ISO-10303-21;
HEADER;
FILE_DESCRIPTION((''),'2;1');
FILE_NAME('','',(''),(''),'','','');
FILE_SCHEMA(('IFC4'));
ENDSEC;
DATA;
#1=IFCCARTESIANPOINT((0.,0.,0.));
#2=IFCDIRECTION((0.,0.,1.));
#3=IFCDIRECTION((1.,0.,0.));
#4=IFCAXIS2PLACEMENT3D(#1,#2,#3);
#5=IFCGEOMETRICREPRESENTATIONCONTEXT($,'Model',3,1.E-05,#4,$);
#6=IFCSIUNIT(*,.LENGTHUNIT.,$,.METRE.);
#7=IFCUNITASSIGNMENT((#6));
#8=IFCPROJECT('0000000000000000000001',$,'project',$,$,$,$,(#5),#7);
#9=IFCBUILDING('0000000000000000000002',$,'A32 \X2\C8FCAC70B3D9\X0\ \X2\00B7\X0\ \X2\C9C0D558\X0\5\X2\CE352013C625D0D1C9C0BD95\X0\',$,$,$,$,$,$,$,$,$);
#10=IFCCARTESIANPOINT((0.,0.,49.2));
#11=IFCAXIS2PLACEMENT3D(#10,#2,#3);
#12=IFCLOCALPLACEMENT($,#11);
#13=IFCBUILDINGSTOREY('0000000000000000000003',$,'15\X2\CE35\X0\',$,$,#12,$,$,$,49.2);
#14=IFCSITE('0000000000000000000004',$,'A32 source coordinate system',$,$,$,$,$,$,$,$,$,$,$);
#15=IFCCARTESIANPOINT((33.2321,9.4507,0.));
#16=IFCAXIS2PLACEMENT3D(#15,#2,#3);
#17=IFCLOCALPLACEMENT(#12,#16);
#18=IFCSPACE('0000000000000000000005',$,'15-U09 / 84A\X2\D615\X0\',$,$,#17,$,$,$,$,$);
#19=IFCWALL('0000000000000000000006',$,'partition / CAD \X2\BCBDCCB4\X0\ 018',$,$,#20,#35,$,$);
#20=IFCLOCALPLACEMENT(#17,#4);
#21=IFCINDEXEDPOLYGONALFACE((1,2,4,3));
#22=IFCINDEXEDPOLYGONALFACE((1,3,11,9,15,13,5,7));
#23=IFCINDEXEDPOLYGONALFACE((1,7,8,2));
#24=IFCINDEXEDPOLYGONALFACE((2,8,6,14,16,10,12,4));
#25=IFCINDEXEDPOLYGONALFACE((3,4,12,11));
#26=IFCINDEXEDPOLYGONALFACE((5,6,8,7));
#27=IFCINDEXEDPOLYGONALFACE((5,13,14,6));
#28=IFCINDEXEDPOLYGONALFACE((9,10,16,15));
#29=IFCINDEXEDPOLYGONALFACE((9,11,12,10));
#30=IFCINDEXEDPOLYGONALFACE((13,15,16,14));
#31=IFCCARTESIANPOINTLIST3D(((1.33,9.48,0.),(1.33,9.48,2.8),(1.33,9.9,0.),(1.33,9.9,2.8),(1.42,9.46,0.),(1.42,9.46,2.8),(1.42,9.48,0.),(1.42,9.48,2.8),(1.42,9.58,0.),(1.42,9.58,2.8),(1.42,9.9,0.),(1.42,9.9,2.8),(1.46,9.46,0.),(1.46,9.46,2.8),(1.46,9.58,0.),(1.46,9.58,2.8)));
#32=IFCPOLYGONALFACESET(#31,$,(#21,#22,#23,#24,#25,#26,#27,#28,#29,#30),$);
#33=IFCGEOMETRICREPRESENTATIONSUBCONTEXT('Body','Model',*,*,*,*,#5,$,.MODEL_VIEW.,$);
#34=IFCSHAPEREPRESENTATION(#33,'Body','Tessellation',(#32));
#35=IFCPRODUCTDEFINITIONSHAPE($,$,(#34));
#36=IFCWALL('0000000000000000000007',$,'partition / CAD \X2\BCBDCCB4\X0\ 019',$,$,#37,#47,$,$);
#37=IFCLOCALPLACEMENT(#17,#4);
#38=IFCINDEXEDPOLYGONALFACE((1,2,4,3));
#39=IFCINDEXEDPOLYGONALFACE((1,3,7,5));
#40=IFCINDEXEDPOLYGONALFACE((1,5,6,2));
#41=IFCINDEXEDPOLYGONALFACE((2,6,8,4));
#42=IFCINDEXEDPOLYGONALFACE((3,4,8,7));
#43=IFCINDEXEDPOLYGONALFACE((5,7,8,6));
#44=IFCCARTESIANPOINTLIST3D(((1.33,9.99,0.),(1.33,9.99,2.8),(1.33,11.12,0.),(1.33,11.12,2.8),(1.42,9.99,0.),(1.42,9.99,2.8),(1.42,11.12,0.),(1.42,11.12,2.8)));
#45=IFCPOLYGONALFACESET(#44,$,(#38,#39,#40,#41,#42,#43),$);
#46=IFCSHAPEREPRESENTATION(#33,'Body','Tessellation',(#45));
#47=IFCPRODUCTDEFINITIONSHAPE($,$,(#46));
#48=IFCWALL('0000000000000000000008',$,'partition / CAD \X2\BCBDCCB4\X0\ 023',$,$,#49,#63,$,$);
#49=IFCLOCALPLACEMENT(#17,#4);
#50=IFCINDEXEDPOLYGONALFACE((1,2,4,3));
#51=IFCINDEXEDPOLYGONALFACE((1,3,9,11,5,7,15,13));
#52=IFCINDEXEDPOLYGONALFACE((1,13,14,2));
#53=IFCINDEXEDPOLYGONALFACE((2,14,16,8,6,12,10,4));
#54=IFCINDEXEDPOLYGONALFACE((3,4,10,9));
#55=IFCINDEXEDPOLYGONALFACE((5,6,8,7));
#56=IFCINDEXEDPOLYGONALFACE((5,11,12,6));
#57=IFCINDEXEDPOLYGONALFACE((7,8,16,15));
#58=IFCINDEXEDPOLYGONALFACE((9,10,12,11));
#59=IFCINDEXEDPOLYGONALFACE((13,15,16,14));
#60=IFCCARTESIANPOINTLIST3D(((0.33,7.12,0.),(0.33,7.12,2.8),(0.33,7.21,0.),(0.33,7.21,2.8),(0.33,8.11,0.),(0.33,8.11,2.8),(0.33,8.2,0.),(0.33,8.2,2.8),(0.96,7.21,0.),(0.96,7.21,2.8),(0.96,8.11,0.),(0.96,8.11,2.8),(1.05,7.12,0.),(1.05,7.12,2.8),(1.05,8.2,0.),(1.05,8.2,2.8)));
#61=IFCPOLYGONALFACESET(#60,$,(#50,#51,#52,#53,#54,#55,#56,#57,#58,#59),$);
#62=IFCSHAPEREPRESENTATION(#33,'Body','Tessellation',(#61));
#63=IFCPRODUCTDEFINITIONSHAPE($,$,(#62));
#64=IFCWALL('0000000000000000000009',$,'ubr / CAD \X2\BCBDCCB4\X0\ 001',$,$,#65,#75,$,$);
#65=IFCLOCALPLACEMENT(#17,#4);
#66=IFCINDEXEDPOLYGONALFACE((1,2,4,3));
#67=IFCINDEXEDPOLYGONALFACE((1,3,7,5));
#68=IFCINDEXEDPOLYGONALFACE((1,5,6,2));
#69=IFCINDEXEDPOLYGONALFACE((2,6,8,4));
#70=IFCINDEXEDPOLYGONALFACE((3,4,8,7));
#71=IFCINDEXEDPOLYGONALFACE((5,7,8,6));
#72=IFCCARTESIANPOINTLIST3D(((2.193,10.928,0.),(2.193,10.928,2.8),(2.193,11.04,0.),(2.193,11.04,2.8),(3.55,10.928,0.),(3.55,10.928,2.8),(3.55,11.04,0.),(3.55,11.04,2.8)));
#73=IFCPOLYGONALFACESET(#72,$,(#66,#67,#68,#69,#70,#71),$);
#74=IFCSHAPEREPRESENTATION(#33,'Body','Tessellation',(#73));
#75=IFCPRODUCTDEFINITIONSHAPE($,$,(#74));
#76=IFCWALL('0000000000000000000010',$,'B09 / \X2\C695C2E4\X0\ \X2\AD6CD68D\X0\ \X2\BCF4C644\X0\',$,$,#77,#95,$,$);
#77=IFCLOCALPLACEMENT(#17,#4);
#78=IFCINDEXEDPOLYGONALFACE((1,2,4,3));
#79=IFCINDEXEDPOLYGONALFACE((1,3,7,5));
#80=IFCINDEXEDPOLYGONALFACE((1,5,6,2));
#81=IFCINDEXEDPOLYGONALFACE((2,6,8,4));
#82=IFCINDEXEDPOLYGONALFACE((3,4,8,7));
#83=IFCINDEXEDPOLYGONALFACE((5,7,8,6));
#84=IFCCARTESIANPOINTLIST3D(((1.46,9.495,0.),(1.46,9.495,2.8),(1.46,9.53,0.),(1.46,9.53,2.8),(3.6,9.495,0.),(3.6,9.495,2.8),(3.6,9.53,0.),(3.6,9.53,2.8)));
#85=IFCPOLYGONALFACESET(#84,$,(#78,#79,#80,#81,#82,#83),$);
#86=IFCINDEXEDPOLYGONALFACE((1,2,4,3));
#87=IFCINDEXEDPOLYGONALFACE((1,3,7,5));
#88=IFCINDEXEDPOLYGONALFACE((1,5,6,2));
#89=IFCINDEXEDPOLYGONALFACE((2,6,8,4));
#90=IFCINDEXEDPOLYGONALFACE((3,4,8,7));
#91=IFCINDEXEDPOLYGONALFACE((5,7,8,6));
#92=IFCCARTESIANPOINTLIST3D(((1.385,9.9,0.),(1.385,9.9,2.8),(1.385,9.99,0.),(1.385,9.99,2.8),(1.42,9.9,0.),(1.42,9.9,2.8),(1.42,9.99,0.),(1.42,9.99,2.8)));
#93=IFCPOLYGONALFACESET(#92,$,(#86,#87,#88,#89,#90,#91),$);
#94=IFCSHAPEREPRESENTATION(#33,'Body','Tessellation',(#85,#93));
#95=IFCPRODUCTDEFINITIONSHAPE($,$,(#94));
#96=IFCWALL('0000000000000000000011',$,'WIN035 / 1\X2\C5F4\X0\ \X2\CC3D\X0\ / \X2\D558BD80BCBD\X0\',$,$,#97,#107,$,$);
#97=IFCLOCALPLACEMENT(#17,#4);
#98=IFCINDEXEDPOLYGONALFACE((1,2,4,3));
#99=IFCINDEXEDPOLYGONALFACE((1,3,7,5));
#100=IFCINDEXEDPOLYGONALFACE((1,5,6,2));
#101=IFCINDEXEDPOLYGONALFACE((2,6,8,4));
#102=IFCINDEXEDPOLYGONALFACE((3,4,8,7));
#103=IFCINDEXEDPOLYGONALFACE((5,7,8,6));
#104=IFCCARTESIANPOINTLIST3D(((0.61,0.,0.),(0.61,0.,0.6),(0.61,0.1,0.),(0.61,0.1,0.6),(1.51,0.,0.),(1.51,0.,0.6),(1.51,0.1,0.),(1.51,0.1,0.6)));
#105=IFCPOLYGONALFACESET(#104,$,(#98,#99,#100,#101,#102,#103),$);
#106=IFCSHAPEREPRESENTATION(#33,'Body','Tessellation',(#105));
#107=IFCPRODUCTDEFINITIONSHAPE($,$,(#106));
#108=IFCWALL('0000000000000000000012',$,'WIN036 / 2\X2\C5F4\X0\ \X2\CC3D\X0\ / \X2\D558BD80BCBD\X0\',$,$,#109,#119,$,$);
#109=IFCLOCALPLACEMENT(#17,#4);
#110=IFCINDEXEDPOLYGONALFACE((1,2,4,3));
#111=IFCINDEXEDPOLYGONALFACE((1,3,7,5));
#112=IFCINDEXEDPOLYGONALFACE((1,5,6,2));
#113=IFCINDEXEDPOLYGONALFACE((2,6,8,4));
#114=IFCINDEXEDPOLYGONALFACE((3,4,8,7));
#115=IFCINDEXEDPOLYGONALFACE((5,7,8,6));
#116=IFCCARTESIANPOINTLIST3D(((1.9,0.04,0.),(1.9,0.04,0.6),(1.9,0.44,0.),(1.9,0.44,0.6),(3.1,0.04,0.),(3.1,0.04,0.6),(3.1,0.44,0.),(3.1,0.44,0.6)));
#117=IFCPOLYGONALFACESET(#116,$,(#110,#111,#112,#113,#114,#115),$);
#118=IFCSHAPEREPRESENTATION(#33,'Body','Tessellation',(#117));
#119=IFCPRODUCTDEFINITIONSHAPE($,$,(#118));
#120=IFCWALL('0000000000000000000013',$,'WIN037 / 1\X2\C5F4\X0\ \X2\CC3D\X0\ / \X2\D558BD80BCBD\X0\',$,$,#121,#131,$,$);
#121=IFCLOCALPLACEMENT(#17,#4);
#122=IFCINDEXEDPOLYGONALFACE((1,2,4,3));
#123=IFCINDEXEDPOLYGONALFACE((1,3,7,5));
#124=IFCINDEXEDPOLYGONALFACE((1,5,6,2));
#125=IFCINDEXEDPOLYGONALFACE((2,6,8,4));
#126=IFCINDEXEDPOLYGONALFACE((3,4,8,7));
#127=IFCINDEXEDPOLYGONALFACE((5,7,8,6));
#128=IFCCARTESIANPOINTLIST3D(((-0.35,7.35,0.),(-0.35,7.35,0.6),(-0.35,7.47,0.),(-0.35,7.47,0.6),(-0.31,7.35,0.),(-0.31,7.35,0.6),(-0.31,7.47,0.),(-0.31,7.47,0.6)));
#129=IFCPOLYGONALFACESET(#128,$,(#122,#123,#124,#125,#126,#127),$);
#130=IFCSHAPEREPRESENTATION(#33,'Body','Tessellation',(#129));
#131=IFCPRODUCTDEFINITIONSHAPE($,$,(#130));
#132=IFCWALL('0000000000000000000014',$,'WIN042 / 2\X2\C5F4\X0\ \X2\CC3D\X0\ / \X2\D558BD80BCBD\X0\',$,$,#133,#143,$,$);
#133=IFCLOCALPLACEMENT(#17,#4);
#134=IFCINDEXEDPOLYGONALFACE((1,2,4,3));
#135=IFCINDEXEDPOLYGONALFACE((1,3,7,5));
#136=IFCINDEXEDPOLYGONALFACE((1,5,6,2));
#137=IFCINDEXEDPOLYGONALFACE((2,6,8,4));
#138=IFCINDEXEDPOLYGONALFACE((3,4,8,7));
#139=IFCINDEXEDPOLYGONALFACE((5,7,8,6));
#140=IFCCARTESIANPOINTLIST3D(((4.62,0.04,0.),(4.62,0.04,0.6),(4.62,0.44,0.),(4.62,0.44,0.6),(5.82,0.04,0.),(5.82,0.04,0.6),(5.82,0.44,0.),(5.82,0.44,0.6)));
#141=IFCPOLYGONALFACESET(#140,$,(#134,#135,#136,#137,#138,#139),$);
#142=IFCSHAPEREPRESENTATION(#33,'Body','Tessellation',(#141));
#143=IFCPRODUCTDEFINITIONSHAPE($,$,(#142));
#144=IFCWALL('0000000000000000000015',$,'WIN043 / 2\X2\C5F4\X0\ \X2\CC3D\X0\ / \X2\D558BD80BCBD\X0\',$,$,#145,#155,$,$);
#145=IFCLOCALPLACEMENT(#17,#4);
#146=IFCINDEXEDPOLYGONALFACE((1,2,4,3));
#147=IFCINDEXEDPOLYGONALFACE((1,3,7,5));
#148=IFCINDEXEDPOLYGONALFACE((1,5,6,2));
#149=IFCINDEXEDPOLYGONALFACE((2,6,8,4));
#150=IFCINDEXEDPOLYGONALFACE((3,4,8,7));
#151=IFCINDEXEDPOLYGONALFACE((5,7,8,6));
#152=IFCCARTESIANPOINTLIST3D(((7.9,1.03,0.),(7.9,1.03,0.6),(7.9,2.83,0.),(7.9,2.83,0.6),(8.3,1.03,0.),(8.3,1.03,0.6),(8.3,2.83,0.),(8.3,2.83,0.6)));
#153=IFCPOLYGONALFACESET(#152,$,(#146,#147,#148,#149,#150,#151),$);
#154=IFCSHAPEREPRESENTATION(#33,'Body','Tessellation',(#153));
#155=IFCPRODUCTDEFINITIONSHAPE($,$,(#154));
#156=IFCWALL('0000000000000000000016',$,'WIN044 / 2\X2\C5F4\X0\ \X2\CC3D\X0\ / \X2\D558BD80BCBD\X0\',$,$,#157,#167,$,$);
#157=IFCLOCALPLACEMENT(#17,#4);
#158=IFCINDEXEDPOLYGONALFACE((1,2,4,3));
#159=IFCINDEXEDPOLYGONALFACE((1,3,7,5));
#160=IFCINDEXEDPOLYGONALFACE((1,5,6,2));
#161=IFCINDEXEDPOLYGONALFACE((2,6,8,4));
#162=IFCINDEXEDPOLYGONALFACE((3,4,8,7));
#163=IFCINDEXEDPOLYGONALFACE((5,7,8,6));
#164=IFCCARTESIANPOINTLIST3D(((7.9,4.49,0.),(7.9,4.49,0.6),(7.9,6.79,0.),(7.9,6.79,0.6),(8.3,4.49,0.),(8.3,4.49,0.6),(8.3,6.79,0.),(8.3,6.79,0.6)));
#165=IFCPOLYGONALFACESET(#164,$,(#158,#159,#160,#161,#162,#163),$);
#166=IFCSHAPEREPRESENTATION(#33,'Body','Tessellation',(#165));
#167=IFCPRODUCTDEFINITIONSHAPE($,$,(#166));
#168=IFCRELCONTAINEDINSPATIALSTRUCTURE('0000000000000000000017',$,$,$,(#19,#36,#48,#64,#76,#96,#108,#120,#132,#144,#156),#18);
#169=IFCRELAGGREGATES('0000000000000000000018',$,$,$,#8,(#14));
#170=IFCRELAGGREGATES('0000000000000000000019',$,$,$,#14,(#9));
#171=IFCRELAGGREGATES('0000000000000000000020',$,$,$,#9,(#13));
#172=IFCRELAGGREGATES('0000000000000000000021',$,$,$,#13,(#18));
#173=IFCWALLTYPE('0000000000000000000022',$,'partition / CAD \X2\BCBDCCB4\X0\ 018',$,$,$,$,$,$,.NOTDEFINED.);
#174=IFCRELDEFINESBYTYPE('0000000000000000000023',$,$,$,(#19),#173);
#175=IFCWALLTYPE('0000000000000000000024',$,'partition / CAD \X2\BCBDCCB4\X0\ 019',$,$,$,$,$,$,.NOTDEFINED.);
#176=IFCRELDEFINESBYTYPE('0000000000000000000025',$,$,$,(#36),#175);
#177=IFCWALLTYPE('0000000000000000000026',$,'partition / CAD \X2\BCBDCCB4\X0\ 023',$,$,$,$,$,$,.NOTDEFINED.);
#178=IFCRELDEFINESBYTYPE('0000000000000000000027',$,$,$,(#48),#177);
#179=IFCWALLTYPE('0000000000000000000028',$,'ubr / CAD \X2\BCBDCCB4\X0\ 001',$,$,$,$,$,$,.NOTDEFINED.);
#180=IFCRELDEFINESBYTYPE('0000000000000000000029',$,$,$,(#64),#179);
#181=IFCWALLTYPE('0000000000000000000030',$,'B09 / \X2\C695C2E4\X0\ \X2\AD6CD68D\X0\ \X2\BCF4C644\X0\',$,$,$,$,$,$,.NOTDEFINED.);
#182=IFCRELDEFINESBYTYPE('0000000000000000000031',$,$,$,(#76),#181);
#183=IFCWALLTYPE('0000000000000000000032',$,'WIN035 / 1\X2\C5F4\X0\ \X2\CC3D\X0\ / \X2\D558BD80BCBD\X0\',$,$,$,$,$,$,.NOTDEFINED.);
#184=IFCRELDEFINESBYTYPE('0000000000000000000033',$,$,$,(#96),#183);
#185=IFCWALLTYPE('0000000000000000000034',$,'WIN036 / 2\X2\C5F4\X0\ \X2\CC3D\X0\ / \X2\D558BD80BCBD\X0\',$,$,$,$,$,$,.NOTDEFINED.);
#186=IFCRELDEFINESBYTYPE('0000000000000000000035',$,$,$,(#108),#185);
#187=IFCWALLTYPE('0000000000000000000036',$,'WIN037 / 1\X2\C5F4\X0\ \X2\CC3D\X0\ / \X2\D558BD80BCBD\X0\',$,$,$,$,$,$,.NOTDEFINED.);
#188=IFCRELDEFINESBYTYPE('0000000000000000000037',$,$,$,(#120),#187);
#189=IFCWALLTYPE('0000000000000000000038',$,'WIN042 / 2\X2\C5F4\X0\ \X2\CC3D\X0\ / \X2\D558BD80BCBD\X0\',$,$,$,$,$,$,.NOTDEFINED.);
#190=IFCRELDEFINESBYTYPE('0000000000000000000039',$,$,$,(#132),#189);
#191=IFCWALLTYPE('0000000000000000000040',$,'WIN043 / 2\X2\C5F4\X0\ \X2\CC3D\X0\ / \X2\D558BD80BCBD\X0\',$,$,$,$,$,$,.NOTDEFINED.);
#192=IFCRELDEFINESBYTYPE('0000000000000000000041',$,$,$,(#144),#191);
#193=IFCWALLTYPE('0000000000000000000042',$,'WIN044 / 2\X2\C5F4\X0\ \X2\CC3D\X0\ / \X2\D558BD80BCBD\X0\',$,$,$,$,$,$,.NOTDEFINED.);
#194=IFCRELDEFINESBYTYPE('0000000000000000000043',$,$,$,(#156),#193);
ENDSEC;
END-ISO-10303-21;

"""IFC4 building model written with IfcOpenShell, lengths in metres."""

from ifc_helpers import new_model, si_unit, frame, origin, origin_with_axes, place, context, subcontext, project, spatial, polyline, outline, extrude, source, transform, mapped, type_object, type_shapes, element, save


model = new_model("IFC4")

# Units and contexts
model_context = context("Model", 3, precision=1e-05, world=origin_with_axes())
body_context = subcontext(model_context, "Body", "Model", "MODEL_VIEW")
ifc_project = project(units=[si_unit("LENGTHUNIT", "METRE")], contexts=[model_context])

# Site, building, storey, space
site = spatial("IfcSite", under=ifc_project, Name="A32 source coordinate system")
building = spatial("IfcBuilding", under=site, Name="A32 주거동 · 지하5층–옥탑지붕")
storey_placement = place(None, frame((0.0, 0.0, 49.2), z_axis=(0.0, 0.0, 1.0), x_axis=(1.0, 0.0, 0.0)))
storey = spatial("IfcBuildingStorey", under=building, at=storey_placement, Name="15층", Elevation=49.2)
space_1_placement = place(storey_placement, frame((33.2321, 9.4507, 0.0), z_axis=(0.0, 0.0, 1.0), x_axis=(1.0, 0.0, 0.0)))
space_1 = spatial("IfcSpace", under=storey, at=space_1_placement, Name="15-U09 / 84A형")

# Walls
wall_type_1 = type_object("IfcWallType", Name="partition / CAD 벽체 018", PredefinedType="NOTDEFINED")
shared_shape_1 = source(origin(), body_context, "Body", "SweptSolid", [
    extrude(outline(polyline([(1.42, 9.58), (1.46, 9.58), (1.46, 9.46), (1.42, 9.46), (1.42, 9.48), (1.33, 9.48), (1.33, 9.9), (1.42, 9.9), (1.42, 9.58)])), origin(), (0.0, 0.0, 1.0), 2.8),
])
type_shapes(wall_type_1, [shared_shape_1])
wall_1_placement = place(space_1_placement, origin_with_axes())
element("IfcWall", 1, at=wall_1_placement, inside=space_1, type_object=wall_type_1, Name="partition / CAD 벽체 018", context=body_context, shape_type="MappedRepresentation", body=[
    mapped(shared_shape_1, transform((0.0, 0.0, 0.0), scale=1.0)),
])
wall_type_2 = type_object("IfcWallType", Name="partition / CAD 벽체 019", PredefinedType="NOTDEFINED")
shared_shape_2 = source(origin(), body_context, "Body", "SweptSolid", [
    extrude(outline(polyline([(1.33, 11.12), (1.42, 11.12), (1.42, 9.99), (1.33, 9.99), (1.33, 11.12)])), origin(), (0.0, 0.0, 1.0), 2.8),
])
type_shapes(wall_type_2, [shared_shape_2])
wall_2_placement = place(space_1_placement, origin_with_axes())
element("IfcWall", 2, at=wall_2_placement, inside=space_1, type_object=wall_type_2, Name="partition / CAD 벽체 019", context=body_context, shape_type="MappedRepresentation", body=[
    mapped(shared_shape_2, transform((0.0, 0.0, 0.0), scale=1.0)),
])
wall_type_3 = type_object("IfcWallType", Name="partition / CAD 벽체 023", PredefinedType="NOTDEFINED")
shared_shape_3 = source(origin(), body_context, "Body", "SweptSolid", [
    extrude(outline(polyline([(0.96, 8.11), (0.33, 8.11), (0.33, 8.2), (1.05, 8.2), (1.05, 7.12), (0.33, 7.12), (0.33, 7.21), (0.96, 7.21), (0.96, 8.11)])), origin(), (0.0, 0.0, 1.0), 2.8),
])
type_shapes(wall_type_3, [shared_shape_3])
wall_3_placement = place(space_1_placement, origin_with_axes())
element("IfcWall", 3, at=wall_3_placement, inside=space_1, type_object=wall_type_3, Name="partition / CAD 벽체 023", context=body_context, shape_type="MappedRepresentation", body=[
    mapped(shared_shape_3, transform((0.0, 0.0, 0.0), scale=1.0)),
])
wall_type_4 = type_object("IfcWallType", Name="ubr / CAD 벽체 001", PredefinedType="NOTDEFINED")
shared_shape_4 = source(origin(), body_context, "Body", "SweptSolid", [
    extrude(outline(polyline([(3.55, 11.04), (3.55, 10.928), (2.193, 10.928), (2.193, 11.04), (3.55, 11.04)])), origin(), (0.0, 0.0, 1.0), 2.8),
])
type_shapes(wall_type_4, [shared_shape_4])
wall_4_placement = place(space_1_placement, origin_with_axes())
element("IfcWall", 4, at=wall_4_placement, inside=space_1, type_object=wall_type_4, Name="ubr / CAD 벽체 001", context=body_context, shape_type="MappedRepresentation", body=[
    mapped(shared_shape_4, transform((0.0, 0.0, 0.0), scale=1.0)),
])
wall_type_5 = type_object("IfcWallType", Name="B09 / 욕실 구획 보완", PredefinedType="NOTDEFINED")
shared_shape_5 = source(origin(), body_context, "Body", "SweptSolid", [
    extrude(outline(polyline([(3.6, 9.53), (3.6, 9.495), (1.46, 9.495), (1.46, 9.53), (3.6, 9.53)])), origin(), (0.0, 0.0, 1.0), 2.8),
    extrude(outline(polyline([(1.42, 9.9), (1.385, 9.9), (1.385, 9.99), (1.42, 9.99), (1.42, 9.9)])), origin(), (0.0, 0.0, 1.0), 2.8),
])
type_shapes(wall_type_5, [shared_shape_5])
wall_5_placement = place(space_1_placement, origin_with_axes())
element("IfcWall", 5, at=wall_5_placement, inside=space_1, type_object=wall_type_5, Name="B09 / 욕실 구획 보완", context=body_context, shape_type="MappedRepresentation", body=[
    mapped(shared_shape_5, transform((0.0, 0.0, 0.0), scale=1.0)),
])
wall_type_6 = type_object("IfcWallType", Name="WIN035 / 1열 창 / 하부벽", PredefinedType="NOTDEFINED")
shared_shape_6 = source(origin(), body_context, "Body", "SweptSolid", [
    extrude(outline(polyline([(0.61, 0.1), (1.51, 0.1), (1.51, 0.0), (0.61, 0.0), (0.61, 0.1)])), origin(), (0.0, 0.0, 1.0), 0.6),
])
type_shapes(wall_type_6, [shared_shape_6])
wall_6_placement = place(space_1_placement, origin_with_axes())
element("IfcWall", 6, at=wall_6_placement, inside=space_1, type_object=wall_type_6, Name="WIN035 / 1열 창 / 하부벽", context=body_context, shape_type="MappedRepresentation", body=[
    mapped(shared_shape_6, transform((0.0, 0.0, 0.0), scale=1.0)),
])
wall_type_7 = type_object("IfcWallType", Name="WIN036 / 2열 창 / 하부벽", PredefinedType="NOTDEFINED")
shared_shape_7 = source(origin(), body_context, "Body", "SweptSolid", [
    extrude(outline(polyline([(1.9, 0.44), (3.1, 0.44), (3.1, 0.04), (1.9, 0.04), (1.9, 0.44)])), origin(), (0.0, 0.0, 1.0), 0.6),
])
type_shapes(wall_type_7, [shared_shape_7])
wall_7_placement = place(space_1_placement, origin_with_axes())
element("IfcWall", 7, at=wall_7_placement, inside=space_1, type_object=wall_type_7, Name="WIN036 / 2열 창 / 하부벽", context=body_context, shape_type="MappedRepresentation", body=[
    mapped(shared_shape_7, transform((0.0, 0.0, 0.0), scale=1.0)),
])
wall_type_8 = type_object("IfcWallType", Name="WIN037 / 1열 창 / 하부벽", PredefinedType="NOTDEFINED")
shared_shape_8 = source(origin(), body_context, "Body", "SweptSolid", [
    extrude(outline(polyline([(-0.31, 7.47), (-0.31, 7.35), (-0.35, 7.35), (-0.35, 7.47), (-0.31, 7.47)])), origin(), (0.0, 0.0, 1.0), 0.6),
])
type_shapes(wall_type_8, [shared_shape_8])
wall_8_placement = place(space_1_placement, origin_with_axes())
element("IfcWall", 8, at=wall_8_placement, inside=space_1, type_object=wall_type_8, Name="WIN037 / 1열 창 / 하부벽", context=body_context, shape_type="MappedRepresentation", body=[
    mapped(shared_shape_8, transform((0.0, 0.0, 0.0), scale=1.0)),
])
wall_type_9 = type_object("IfcWallType", Name="WIN042 / 2열 창 / 하부벽", PredefinedType="NOTDEFINED")
shared_shape_9 = source(origin(), body_context, "Body", "SweptSolid", [
    extrude(outline(polyline([(4.62, 0.44), (5.82, 0.44), (5.82, 0.04), (4.62, 0.04), (4.62, 0.44)])), origin(), (0.0, 0.0, 1.0), 0.6),
])
type_shapes(wall_type_9, [shared_shape_9])
wall_9_placement = place(space_1_placement, origin_with_axes())
element("IfcWall", 9, at=wall_9_placement, inside=space_1, type_object=wall_type_9, Name="WIN042 / 2열 창 / 하부벽", context=body_context, shape_type="MappedRepresentation", body=[
    mapped(shared_shape_9, transform((0.0, 0.0, 0.0), scale=1.0)),
])
wall_type_10 = type_object("IfcWallType", Name="WIN043 / 2열 창 / 하부벽", PredefinedType="NOTDEFINED")
shared_shape_10 = source(origin(), body_context, "Body", "SweptSolid", [
    extrude(outline(polyline([(7.9, 2.83), (8.3, 2.83), (8.3, 1.03), (7.9, 1.03), (7.9, 2.83)])), origin(), (0.0, 0.0, 1.0), 0.6),
])
type_shapes(wall_type_10, [shared_shape_10])
wall_10_placement = place(space_1_placement, origin_with_axes())
element("IfcWall", 10, at=wall_10_placement, inside=space_1, type_object=wall_type_10, Name="WIN043 / 2열 창 / 하부벽", context=body_context, shape_type="MappedRepresentation", body=[
    mapped(shared_shape_10, transform((0.0, 0.0, 0.0), scale=1.0)),
])
wall_type_11 = type_object("IfcWallType", Name="WIN044 / 2열 창 / 하부벽", PredefinedType="NOTDEFINED")
shared_shape_11 = source(origin(), body_context, "Body", "SweptSolid", [
    extrude(outline(polyline([(7.9, 6.79), (8.3, 6.79), (8.3, 4.49), (7.9, 4.49), (7.9, 6.79)])), origin(), (0.0, 0.0, 1.0), 0.6),
])
type_shapes(wall_type_11, [shared_shape_11])
wall_11_placement = place(space_1_placement, origin_with_axes())
element("IfcWall", 11, at=wall_11_placement, inside=space_1, type_object=wall_type_11, Name="WIN044 / 2열 창 / 하부벽", context=body_context, shape_type="MappedRepresentation", body=[
    mapped(shared_shape_11, transform((0.0, 0.0, 0.0), scale=1.0)),
])

save(model, "model.ifc")
